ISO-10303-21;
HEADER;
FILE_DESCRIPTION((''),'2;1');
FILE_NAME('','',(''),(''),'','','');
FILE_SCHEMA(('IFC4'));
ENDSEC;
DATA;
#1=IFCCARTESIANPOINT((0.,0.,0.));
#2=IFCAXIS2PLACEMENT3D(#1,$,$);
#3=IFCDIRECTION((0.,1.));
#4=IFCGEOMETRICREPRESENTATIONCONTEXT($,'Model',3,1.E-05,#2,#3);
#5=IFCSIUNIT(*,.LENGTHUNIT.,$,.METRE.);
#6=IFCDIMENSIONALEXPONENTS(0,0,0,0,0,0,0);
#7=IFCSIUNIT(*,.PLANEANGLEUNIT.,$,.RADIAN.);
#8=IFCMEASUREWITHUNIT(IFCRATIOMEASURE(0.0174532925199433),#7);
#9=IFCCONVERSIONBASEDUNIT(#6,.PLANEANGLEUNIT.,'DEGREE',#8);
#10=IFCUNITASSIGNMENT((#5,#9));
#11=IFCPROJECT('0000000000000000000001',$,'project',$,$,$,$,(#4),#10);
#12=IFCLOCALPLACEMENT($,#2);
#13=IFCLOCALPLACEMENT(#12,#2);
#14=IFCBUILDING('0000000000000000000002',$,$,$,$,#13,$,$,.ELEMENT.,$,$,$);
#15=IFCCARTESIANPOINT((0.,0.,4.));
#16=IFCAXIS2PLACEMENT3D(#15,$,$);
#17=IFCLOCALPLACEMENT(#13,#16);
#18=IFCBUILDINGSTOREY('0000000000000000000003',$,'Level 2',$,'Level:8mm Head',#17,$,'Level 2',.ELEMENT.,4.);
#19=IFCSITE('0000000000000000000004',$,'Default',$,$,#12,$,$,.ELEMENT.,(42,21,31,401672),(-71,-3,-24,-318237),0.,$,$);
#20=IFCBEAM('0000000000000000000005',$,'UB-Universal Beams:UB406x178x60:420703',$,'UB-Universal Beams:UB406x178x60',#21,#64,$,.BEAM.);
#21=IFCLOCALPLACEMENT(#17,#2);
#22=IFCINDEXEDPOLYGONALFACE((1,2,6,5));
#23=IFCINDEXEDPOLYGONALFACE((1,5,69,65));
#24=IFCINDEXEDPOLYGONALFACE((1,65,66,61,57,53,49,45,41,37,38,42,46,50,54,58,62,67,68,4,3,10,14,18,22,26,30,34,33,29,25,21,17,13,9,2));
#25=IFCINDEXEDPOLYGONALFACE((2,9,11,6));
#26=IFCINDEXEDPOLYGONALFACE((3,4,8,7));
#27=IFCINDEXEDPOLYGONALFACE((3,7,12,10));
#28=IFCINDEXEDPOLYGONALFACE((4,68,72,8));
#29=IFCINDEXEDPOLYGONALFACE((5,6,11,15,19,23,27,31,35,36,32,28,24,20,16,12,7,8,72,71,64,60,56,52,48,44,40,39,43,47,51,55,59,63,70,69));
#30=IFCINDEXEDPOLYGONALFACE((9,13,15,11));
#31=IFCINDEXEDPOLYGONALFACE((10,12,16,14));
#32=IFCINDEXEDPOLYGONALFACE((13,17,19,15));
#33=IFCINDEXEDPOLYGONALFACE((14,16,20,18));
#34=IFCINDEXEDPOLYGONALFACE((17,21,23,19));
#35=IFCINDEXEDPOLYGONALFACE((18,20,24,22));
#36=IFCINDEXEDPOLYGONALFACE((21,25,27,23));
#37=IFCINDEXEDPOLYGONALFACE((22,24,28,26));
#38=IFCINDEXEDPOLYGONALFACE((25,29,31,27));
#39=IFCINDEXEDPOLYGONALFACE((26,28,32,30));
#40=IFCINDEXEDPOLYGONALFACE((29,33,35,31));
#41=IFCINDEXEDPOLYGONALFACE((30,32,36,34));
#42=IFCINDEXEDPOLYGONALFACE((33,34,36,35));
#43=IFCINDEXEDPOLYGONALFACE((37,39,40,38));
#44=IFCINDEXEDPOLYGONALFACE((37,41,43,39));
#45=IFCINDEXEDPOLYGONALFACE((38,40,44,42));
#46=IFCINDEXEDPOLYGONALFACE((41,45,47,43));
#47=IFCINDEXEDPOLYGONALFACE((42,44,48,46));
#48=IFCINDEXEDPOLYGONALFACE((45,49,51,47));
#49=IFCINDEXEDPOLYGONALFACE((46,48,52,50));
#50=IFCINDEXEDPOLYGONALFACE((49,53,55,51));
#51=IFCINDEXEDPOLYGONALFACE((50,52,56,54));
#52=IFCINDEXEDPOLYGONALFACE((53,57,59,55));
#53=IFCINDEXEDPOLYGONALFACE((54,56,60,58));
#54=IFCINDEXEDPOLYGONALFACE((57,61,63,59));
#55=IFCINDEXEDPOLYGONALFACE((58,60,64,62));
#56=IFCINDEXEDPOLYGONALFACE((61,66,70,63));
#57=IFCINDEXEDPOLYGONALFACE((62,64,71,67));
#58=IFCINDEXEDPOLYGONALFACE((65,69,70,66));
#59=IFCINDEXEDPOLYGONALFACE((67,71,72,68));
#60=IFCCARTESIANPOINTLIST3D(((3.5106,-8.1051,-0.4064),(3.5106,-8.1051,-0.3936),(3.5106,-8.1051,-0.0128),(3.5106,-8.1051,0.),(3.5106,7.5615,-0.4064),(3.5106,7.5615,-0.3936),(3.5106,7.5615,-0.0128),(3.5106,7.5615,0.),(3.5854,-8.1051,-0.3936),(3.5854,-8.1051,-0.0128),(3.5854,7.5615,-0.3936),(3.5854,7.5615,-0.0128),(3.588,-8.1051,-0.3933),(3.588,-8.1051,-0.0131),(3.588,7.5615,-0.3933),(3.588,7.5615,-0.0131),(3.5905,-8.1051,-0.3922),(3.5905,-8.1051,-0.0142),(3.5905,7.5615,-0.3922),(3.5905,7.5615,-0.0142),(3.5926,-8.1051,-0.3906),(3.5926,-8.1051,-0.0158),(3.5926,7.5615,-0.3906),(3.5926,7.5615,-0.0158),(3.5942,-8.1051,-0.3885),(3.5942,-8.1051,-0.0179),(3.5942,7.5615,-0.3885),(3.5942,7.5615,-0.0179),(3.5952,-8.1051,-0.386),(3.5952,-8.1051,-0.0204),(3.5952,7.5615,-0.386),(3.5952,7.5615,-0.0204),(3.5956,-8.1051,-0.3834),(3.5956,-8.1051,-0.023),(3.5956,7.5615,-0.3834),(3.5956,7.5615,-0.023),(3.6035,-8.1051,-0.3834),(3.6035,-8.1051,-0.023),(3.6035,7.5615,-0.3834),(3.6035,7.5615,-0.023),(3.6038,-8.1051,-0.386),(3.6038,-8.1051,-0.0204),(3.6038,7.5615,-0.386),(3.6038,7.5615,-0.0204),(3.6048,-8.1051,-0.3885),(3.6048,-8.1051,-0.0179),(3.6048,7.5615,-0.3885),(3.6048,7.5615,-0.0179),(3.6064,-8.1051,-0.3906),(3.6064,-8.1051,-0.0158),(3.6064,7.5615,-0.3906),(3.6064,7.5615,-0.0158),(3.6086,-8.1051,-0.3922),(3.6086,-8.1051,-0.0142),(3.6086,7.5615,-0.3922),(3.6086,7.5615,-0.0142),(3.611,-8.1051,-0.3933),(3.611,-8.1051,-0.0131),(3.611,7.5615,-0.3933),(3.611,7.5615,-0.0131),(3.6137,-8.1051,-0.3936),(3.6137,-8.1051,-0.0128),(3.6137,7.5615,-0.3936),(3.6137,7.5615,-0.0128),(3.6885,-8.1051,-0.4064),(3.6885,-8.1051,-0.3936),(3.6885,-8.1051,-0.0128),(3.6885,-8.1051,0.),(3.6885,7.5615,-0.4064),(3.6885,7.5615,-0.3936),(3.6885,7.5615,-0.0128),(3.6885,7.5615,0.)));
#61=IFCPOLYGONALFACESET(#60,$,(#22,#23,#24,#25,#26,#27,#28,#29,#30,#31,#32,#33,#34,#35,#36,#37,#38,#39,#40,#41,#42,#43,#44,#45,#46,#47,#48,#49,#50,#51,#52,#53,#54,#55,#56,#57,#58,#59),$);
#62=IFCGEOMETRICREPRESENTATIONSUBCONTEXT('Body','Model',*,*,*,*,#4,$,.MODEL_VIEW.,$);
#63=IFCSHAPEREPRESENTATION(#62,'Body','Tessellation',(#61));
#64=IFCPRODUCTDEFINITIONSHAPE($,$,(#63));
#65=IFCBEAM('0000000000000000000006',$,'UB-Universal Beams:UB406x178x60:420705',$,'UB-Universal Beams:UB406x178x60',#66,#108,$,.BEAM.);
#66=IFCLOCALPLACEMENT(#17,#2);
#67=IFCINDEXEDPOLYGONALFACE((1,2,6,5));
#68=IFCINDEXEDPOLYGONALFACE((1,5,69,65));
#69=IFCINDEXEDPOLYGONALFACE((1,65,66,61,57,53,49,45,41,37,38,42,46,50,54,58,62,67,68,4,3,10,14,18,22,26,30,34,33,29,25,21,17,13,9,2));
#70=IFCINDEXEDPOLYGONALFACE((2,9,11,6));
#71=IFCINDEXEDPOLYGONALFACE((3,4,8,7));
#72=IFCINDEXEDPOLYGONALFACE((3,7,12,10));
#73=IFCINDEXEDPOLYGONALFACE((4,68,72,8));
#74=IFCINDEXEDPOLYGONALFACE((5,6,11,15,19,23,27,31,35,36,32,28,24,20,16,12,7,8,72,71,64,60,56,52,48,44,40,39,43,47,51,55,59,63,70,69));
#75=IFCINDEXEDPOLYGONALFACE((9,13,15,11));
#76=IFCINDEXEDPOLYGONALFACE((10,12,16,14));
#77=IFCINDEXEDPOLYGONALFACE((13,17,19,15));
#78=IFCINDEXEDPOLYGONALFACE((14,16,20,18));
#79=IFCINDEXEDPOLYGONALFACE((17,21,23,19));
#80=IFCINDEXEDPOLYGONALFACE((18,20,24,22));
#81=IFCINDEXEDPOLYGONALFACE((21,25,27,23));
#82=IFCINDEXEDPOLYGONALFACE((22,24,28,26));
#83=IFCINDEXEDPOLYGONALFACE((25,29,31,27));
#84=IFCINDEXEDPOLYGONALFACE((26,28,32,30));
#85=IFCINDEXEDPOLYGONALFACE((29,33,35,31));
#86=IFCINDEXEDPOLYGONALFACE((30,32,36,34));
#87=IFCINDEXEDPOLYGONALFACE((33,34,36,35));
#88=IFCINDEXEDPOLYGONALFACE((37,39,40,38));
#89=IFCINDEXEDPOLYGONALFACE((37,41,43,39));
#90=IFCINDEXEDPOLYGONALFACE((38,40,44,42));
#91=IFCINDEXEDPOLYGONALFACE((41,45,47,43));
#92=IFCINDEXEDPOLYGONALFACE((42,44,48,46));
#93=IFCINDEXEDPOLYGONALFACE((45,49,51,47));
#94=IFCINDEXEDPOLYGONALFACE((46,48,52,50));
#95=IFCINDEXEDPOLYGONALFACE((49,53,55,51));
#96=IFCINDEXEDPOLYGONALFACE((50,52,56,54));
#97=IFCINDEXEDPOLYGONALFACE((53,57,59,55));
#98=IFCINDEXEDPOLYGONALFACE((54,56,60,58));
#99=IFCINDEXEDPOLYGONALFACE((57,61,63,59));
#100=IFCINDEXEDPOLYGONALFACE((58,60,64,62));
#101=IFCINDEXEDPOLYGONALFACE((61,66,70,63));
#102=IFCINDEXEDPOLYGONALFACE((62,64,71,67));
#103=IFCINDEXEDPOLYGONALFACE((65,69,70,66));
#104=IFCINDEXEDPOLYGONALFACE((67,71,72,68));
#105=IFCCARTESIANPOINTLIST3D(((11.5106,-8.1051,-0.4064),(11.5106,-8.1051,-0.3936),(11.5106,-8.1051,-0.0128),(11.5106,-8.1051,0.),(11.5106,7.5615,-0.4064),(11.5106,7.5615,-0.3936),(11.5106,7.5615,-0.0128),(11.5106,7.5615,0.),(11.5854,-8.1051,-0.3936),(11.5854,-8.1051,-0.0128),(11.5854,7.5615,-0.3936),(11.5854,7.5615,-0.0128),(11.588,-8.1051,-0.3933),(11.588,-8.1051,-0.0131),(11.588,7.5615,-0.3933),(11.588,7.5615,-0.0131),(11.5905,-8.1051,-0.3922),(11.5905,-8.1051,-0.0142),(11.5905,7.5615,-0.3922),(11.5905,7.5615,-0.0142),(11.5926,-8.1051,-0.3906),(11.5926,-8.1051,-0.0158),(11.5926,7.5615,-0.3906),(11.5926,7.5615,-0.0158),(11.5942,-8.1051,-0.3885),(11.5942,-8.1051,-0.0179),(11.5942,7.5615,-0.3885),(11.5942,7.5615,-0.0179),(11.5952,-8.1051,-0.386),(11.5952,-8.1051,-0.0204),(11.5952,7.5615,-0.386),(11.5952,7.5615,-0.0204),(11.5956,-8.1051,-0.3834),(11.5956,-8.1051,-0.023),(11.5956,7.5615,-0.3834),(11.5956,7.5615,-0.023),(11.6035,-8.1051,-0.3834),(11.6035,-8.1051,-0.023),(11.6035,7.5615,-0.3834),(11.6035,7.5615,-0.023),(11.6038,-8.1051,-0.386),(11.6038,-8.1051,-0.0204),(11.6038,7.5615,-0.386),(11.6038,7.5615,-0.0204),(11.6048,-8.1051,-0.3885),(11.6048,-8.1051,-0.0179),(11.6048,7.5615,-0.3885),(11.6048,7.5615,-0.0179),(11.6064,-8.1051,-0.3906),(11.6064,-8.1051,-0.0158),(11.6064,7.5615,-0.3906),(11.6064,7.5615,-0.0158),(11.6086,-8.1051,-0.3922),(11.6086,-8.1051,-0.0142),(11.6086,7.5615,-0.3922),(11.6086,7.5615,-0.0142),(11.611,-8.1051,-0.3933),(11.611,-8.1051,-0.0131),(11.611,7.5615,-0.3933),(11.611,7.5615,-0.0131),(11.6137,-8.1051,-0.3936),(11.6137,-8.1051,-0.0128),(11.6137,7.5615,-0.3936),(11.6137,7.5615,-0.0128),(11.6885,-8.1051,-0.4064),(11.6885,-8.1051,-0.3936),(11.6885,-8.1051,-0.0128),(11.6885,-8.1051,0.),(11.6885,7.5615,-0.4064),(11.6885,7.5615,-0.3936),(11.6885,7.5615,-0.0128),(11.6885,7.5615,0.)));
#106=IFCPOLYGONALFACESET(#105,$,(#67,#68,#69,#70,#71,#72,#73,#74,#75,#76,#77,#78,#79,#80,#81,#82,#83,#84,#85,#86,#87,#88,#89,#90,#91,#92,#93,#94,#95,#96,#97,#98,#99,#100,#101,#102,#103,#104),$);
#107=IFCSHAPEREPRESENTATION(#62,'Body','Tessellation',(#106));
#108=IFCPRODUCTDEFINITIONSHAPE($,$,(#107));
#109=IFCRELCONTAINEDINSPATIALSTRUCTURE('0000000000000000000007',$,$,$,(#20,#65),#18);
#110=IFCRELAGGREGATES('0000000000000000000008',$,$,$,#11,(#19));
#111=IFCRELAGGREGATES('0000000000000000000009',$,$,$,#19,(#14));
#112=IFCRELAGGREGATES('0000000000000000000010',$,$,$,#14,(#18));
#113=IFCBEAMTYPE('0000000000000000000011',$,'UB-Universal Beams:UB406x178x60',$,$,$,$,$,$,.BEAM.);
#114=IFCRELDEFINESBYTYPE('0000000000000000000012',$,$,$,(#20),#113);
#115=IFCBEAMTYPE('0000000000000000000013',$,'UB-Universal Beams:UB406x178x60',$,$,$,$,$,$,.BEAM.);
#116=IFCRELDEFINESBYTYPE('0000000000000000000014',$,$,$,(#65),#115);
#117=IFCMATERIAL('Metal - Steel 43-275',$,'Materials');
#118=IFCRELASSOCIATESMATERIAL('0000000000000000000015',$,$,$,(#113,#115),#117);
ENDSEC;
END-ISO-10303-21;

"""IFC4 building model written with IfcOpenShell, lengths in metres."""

from ifc_helpers import new_model, entity, si_unit, converted_unit, direction, frame, frame_2d, origin, place, context, subcontext, project, spatial, i_section, extrude, source, transform, mapped, material, material_profile, profile_set, type_object, type_shapes, element, save


model = new_model("IFC4")

# Units and contexts
model_context = context("Model", 3, precision=1e-05, world=origin(), true_north=direction((0.0, 1.0)))
body_context = subcontext(model_context, "Body", "Model", "MODEL_VIEW")
ifc_project = project(units=[si_unit("LENGTHUNIT", "METRE"), converted_unit("PLANEANGLEUNIT", "DEGREE", entity("IfcRatioMeasure", 0.0174532925199433), si_unit("PLANEANGLEUNIT", "RADIAN"), dimensions=[0, 0, 0, 0, 0, 0, 0])], contexts=[model_context])

# Site, building, storey
site_placement = place(None, origin())
site = spatial("IfcSite", under=ifc_project, at=site_placement, Name="Default", CompositionType="ELEMENT", RefLatitude=(42, 21, 31, 401672), RefLongitude=(-71, -3, -24, -318237), RefElevation=0.0)
building_placement = place(site_placement, origin())
building = spatial("IfcBuilding", under=site, at=building_placement, CompositionType="ELEMENT")
storey_placement = place(building_placement, frame((0.0, 0.0, 4.0)))
storey = spatial("IfcBuildingStorey", under=building, at=storey_placement, Name="Level 2", ObjectType="Level:8mm Head", LongName="Level 2", CompositionType="ELEMENT", Elevation=4.0)

# Shared definitions
ifc_material_1 = material(Name="Metal - Steel 43-275", Category="Materials")
ifc_material_profile_1 = material_profile(ifc_material_1, i_section(OverallWidth=0.1779, OverallDepth=0.4064, WebThickness=0.0079, FlangeThickness=0.0128, FilletRadius=0.0102, at=frame_2d((0.0, 0.0), x_axis=(0.0, 1.0))), Name="UB406x178x60")
ifc_profile_set_1 = profile_set([ifc_material_profile_1], Name="UB406x178x60")

# Beams
beam_type_1 = type_object("IfcBeamType", Name="UB-Universal Beams:UB406x178x60", PredefinedType="BEAM", material=ifc_profile_set_1)
shared_shape_1 = source(origin(), body_context, "Body", "SweptSolid", [
    extrude(i_section(OverallWidth=0.1779, OverallDepth=0.4064, WebThickness=0.0079, FlangeThickness=0.0128, FilletRadius=0.0102, at=frame_2d((0.0, 0.0), x_axis=(1.0, 0.0))), frame((3.5995, -8.1051, 3.7968), z_axis=(0.0, 1.0, 0.0), x_axis=(-1.0, 0.0, 0.0)), (0.0, 0.0, 1.0), 15.6666),
])
type_shapes(beam_type_1, [shared_shape_1])
beam_1_placement = place(storey_placement, frame((0.0, 0.0, -4.0)))
element("IfcBeam", 1, at=beam_1_placement, inside=storey, type_object=beam_type_1, Name="UB-Universal Beams:UB406x178x60:420703", ObjectType="UB-Universal Beams:UB406x178x60", PredefinedType="BEAM", context=body_context, shape_type="MappedRepresentation", body=[
    mapped(shared_shape_1, transform((0.0, 0.0, 0.0), scale=1.0)),
])
beam_type_2 = type_object("IfcBeamType", Name="UB-Universal Beams:UB406x178x60", PredefinedType="BEAM", material=ifc_profile_set_1)
shared_shape_2 = source(origin(), body_context, "Body", "SweptSolid", [
    extrude(i_section(OverallWidth=0.1779, OverallDepth=0.4064, WebThickness=0.0079, FlangeThickness=0.0128, FilletRadius=0.0102, at=frame_2d((0.0, 0.0), x_axis=(1.0, 0.0))), frame((11.5995, -8.1051, 3.7968), z_axis=(0.0, 1.0, 0.0), x_axis=(-1.0, 0.0, 0.0)), (0.0, 0.0, 1.0), 15.6666),
])
type_shapes(beam_type_2, [shared_shape_2])
beam_2_placement = place(storey_placement, frame((0.0, 0.0, -4.0)))
element("IfcBeam", 2, at=beam_2_placement, inside=storey, type_object=beam_type_2, Name="UB-Universal Beams:UB406x178x60:420705", ObjectType="UB-Universal Beams:UB406x178x60", PredefinedType="BEAM", context=body_context, shape_type="MappedRepresentation", body=[
    mapped(shared_shape_2, transform((0.0, 0.0, 0.0), scale=1.0)),
])

save(model, "model.ifc")
